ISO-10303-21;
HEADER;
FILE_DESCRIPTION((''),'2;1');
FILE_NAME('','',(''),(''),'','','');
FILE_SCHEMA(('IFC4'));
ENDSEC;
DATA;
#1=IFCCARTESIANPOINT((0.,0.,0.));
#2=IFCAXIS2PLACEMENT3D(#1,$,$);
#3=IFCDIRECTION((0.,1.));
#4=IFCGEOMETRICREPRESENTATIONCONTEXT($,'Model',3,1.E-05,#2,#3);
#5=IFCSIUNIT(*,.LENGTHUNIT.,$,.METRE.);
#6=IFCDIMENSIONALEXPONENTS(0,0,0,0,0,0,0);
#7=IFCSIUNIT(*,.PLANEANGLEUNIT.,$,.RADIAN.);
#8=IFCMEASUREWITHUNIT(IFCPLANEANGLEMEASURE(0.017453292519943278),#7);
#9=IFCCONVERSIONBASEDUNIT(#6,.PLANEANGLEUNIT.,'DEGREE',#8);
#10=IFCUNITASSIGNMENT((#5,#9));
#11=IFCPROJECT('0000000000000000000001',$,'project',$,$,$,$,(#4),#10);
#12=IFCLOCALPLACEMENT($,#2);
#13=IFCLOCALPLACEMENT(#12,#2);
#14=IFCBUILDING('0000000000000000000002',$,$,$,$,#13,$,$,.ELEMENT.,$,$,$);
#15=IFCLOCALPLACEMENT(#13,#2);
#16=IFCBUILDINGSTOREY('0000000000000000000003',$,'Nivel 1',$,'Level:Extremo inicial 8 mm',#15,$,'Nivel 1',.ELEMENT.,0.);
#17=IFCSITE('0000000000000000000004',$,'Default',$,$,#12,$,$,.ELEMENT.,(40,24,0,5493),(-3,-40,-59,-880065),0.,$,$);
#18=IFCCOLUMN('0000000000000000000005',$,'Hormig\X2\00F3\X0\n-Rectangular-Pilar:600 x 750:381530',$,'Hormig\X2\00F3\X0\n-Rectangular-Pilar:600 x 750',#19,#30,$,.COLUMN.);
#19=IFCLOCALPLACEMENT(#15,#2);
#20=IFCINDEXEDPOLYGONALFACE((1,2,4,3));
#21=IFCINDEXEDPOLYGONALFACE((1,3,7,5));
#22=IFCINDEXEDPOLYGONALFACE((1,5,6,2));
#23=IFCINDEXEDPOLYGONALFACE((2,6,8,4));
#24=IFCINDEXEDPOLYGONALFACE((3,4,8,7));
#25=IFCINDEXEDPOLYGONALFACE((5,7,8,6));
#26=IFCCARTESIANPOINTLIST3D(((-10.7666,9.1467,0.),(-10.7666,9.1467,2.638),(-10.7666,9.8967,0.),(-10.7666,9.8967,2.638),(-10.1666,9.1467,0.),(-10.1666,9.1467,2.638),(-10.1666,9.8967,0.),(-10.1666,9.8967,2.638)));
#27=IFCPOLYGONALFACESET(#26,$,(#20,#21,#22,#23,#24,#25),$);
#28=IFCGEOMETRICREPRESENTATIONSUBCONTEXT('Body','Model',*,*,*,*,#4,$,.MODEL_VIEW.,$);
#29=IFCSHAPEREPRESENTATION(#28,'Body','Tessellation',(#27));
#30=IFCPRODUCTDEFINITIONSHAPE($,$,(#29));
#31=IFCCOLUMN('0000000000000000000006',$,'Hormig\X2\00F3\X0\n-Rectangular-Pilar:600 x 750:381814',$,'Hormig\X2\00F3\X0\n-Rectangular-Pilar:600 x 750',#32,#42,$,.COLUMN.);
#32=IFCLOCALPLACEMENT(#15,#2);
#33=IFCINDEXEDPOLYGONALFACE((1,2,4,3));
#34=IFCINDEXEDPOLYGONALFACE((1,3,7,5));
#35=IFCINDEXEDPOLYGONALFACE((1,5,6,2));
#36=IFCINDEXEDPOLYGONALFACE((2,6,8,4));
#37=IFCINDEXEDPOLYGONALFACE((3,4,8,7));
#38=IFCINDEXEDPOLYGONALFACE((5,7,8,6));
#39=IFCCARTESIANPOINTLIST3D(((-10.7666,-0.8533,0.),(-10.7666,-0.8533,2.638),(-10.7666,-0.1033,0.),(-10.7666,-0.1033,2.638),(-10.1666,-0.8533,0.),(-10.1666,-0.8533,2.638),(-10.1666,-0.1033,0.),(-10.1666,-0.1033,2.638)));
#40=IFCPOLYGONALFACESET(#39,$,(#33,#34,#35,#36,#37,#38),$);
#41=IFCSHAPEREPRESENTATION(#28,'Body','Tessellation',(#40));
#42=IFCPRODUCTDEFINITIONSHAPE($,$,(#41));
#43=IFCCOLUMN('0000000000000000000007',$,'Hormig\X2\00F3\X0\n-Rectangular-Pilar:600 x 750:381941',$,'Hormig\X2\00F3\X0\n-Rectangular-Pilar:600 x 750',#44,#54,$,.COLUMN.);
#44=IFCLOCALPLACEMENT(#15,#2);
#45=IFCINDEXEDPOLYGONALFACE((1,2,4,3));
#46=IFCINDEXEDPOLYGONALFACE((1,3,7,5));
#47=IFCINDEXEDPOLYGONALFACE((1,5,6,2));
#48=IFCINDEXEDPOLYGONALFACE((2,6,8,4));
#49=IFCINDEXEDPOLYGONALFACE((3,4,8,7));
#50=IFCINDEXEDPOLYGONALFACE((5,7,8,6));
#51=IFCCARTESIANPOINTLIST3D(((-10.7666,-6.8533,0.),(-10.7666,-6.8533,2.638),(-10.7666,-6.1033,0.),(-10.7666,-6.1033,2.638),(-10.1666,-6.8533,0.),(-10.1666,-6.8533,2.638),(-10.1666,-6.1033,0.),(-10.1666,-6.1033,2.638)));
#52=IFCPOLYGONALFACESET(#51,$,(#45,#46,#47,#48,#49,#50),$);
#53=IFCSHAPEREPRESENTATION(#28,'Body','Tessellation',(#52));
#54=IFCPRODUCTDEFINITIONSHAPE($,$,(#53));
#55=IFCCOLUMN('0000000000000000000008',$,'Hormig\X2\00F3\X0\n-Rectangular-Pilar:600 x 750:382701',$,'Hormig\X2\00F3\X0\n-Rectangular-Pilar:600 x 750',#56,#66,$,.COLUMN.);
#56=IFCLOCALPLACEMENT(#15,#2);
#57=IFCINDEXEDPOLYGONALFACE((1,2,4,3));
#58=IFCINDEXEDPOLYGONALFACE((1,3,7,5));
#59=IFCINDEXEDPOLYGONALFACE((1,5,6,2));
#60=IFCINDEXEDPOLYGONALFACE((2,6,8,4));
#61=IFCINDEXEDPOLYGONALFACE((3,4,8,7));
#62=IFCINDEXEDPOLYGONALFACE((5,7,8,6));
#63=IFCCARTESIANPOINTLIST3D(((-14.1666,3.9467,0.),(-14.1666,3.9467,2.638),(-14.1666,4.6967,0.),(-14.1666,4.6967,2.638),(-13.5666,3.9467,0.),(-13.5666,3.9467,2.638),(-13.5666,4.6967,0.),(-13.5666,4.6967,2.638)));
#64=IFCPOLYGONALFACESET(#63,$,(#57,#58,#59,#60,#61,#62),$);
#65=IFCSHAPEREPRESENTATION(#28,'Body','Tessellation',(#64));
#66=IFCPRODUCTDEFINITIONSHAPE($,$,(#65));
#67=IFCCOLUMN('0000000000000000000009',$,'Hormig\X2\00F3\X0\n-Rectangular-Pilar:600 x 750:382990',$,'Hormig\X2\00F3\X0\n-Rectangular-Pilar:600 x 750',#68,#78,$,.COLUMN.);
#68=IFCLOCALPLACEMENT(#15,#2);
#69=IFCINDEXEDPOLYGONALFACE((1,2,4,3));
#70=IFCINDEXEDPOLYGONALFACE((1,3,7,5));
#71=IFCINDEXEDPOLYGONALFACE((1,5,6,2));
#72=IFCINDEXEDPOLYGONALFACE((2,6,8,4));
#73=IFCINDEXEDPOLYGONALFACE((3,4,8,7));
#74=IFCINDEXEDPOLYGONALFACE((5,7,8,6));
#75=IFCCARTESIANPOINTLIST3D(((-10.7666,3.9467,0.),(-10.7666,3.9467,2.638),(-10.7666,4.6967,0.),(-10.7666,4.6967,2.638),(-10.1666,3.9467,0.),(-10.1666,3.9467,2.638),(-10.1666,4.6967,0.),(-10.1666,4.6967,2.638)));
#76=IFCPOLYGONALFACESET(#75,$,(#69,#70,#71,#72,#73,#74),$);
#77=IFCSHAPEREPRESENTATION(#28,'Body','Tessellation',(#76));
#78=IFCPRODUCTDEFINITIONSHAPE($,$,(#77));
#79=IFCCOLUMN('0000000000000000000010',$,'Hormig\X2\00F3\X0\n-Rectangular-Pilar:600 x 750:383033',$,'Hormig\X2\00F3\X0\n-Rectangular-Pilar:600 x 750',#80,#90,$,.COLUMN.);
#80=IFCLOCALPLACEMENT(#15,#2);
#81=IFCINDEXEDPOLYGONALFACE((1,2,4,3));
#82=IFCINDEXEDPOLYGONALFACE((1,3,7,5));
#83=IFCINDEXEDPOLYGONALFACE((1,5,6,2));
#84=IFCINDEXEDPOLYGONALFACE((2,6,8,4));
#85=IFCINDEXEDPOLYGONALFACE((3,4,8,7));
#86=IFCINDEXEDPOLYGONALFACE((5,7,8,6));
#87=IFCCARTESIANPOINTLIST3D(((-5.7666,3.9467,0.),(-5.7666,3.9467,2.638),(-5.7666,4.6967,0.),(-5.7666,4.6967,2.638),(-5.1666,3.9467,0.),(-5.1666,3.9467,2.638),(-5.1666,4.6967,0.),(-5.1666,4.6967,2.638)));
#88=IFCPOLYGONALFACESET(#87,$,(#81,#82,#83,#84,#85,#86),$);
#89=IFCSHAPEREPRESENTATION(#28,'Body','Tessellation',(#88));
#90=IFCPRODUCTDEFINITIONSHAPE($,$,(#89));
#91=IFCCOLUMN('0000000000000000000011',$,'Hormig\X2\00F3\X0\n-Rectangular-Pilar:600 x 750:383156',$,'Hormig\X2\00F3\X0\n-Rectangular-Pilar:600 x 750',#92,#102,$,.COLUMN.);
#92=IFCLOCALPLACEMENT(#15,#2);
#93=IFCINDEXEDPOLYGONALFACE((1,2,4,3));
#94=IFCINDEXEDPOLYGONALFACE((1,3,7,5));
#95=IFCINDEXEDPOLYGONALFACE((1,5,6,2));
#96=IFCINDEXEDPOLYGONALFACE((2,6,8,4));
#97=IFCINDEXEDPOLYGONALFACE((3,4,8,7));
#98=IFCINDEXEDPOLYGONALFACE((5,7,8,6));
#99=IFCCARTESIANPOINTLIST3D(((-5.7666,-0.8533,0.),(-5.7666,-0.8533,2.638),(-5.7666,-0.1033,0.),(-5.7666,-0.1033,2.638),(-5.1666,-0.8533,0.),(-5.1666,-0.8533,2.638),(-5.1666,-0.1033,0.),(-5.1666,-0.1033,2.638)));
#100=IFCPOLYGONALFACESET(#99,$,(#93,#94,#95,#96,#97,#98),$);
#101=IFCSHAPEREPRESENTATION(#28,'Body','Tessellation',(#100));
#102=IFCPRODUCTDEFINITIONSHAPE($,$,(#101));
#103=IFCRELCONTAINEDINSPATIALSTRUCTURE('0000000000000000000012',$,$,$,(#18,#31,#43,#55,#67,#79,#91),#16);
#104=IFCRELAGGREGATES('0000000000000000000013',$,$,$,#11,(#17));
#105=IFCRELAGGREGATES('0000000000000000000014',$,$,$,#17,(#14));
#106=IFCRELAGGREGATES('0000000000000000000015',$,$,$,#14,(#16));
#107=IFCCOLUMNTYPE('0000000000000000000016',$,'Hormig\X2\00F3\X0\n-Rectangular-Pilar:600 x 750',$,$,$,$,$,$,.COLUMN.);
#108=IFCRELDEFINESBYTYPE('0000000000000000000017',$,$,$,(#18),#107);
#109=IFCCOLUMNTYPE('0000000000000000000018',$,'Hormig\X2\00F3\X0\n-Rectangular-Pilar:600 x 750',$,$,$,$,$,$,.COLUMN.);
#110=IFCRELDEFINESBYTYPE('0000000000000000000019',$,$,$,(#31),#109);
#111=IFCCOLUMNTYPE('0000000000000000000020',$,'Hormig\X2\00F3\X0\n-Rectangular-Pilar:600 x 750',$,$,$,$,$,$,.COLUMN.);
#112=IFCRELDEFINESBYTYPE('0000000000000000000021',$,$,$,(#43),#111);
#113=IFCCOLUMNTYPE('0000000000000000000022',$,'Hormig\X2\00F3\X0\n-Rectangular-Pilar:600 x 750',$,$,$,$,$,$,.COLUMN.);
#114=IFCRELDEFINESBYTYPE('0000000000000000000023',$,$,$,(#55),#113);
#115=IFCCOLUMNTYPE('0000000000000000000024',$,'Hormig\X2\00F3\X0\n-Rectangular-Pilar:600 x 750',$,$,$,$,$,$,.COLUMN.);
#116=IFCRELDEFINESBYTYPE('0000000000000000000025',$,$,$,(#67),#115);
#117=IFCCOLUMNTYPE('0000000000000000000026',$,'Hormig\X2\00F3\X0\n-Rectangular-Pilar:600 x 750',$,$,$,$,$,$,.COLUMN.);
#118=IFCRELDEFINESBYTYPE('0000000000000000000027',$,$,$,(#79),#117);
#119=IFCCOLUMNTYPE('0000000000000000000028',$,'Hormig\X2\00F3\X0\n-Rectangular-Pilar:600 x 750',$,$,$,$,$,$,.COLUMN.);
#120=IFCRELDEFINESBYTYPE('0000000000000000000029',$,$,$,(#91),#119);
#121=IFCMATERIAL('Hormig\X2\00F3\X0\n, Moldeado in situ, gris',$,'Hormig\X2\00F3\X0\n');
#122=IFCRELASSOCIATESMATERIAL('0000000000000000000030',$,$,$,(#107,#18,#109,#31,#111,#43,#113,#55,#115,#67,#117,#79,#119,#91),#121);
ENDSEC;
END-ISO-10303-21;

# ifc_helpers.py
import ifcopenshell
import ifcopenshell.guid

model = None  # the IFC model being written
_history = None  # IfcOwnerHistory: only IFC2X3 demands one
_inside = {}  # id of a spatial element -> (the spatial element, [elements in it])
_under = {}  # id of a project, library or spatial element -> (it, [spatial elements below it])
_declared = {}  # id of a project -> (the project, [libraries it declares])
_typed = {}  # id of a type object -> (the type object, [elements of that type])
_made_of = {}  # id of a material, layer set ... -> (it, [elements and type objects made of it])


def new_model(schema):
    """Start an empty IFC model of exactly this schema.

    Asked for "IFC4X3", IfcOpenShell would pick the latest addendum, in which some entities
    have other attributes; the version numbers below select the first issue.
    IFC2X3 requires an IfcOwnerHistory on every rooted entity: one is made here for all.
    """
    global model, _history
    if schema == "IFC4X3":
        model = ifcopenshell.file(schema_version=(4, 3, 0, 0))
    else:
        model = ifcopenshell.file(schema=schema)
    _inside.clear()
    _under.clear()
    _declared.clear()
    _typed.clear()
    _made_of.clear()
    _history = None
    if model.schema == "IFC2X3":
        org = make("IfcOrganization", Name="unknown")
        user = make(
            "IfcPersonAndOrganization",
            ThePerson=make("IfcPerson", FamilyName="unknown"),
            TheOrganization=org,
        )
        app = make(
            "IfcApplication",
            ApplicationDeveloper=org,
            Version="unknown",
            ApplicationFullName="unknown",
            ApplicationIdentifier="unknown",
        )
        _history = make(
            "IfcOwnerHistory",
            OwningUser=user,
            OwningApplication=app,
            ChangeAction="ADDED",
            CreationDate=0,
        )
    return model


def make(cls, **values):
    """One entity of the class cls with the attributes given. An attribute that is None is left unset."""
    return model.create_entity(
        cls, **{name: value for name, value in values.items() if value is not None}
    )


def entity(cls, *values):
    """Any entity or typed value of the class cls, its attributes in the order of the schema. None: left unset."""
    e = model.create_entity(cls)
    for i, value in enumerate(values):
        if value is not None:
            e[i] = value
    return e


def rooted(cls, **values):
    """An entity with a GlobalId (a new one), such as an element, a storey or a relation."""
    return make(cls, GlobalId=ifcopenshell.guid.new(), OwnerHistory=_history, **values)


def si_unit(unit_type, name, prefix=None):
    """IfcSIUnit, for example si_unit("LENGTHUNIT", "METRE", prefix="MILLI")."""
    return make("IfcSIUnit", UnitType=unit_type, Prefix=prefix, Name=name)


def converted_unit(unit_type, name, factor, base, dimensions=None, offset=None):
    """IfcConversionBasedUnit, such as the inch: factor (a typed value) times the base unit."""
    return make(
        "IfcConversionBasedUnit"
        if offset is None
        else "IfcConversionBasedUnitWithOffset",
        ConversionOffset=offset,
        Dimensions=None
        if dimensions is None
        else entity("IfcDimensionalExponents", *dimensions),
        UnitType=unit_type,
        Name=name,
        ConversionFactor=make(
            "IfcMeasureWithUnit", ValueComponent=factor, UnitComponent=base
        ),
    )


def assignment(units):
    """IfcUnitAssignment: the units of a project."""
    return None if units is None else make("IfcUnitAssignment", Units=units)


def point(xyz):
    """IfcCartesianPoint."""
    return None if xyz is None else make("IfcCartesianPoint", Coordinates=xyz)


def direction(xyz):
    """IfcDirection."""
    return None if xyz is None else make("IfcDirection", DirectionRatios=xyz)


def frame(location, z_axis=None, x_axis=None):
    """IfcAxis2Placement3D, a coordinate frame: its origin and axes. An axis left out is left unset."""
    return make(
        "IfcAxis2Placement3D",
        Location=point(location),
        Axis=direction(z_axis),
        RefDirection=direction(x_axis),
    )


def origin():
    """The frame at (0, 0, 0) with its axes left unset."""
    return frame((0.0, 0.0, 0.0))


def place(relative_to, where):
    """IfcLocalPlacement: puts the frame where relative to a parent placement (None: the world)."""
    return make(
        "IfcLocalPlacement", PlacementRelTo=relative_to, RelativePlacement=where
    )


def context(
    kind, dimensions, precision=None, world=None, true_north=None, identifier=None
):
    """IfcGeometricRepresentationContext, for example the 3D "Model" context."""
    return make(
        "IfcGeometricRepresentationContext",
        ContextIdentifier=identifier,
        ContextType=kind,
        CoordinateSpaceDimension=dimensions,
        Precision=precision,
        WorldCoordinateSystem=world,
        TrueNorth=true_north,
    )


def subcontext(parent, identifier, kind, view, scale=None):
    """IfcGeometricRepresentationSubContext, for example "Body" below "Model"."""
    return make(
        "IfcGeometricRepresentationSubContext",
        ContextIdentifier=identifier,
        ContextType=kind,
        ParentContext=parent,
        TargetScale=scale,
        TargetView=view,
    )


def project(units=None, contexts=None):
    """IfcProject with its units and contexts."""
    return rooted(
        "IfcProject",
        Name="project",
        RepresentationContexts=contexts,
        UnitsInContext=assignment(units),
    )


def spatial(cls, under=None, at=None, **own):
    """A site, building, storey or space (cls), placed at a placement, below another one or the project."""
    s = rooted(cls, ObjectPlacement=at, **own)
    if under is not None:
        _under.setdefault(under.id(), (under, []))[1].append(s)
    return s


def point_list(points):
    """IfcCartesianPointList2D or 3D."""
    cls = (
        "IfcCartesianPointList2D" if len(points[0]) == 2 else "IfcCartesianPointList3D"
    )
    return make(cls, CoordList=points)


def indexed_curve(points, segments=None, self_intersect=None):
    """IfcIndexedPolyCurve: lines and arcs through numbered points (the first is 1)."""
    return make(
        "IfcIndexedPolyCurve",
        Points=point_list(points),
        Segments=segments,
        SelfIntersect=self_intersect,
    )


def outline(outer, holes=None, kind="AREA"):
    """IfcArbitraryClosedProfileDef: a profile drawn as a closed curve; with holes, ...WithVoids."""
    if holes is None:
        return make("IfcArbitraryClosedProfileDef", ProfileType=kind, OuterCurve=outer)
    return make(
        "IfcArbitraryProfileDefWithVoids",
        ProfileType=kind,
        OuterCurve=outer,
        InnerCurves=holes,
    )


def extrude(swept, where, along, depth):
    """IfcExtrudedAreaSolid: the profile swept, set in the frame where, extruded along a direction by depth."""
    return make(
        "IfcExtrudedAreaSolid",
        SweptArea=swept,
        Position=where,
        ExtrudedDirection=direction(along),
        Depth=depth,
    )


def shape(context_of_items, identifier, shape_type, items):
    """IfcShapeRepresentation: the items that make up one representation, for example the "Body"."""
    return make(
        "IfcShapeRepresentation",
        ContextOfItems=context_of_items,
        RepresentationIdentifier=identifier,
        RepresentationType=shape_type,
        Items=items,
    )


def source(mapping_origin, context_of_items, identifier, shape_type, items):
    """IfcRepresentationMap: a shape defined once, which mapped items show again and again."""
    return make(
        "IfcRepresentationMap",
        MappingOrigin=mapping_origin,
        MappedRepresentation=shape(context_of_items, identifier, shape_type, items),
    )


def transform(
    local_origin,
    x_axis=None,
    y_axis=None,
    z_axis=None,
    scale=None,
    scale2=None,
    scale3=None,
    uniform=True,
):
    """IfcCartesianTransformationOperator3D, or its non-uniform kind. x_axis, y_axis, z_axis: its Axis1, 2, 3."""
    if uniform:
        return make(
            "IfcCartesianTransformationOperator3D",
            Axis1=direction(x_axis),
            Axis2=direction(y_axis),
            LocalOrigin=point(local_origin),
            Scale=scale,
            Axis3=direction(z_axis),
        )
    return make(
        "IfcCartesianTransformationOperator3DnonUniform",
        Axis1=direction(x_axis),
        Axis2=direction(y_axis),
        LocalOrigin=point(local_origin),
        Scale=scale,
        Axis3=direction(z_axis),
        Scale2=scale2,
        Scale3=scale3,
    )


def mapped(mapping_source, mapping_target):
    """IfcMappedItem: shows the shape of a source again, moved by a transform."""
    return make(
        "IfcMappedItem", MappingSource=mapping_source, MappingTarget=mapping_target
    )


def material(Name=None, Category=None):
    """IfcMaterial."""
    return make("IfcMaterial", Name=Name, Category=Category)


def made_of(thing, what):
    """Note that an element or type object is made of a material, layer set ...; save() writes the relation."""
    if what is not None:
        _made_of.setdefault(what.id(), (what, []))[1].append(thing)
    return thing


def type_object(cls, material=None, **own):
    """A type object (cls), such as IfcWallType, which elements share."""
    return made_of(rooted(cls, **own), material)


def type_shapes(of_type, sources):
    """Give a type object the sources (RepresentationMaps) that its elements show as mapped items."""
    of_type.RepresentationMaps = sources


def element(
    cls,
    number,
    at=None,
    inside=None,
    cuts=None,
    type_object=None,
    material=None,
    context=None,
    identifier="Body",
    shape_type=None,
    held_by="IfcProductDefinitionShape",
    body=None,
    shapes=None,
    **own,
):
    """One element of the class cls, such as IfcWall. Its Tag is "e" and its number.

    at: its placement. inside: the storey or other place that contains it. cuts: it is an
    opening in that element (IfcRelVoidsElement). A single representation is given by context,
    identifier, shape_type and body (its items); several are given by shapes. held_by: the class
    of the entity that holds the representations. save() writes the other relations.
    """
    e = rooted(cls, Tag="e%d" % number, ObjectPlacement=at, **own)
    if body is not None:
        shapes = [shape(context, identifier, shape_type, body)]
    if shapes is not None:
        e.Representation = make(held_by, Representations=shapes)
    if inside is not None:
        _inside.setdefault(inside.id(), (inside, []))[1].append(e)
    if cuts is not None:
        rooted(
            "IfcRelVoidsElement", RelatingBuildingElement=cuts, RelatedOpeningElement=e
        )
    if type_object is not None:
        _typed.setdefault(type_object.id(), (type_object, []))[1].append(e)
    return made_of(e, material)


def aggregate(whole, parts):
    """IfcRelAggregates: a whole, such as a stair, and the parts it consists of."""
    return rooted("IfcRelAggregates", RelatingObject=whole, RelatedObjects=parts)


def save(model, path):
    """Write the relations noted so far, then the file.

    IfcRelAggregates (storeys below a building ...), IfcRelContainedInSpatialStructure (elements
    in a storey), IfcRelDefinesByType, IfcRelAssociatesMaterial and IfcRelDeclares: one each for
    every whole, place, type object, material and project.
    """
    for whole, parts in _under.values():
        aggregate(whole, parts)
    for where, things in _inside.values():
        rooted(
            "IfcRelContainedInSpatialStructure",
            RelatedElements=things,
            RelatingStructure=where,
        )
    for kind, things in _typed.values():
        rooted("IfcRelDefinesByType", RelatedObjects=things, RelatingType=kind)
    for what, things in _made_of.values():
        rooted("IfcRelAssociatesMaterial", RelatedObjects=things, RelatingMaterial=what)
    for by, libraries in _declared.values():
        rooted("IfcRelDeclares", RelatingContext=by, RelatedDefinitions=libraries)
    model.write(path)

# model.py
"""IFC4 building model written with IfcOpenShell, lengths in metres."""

from ifc_helpers import new_model, entity, si_unit, converted_unit, direction, frame, origin, place, context, subcontext, project, spatial, indexed_curve, outline, extrude, source, transform, mapped, material, type_object, type_shapes, element, save


model = new_model("IFC4")

# Units and contexts
model_context = context("Model", 3, precision=1e-05, world=origin(), true_north=direction((0.0, 1.0)))
body_context = subcontext(model_context, "Body", "Model", "MODEL_VIEW")
ifc_project = project(units=[si_unit("LENGTHUNIT", "METRE"), converted_unit("PLANEANGLEUNIT", "DEGREE", entity("IfcPlaneAngleMeasure", 0.017453292519943278), si_unit("PLANEANGLEUNIT", "RADIAN"), dimensions=[0, 0, 0, 0, 0, 0, 0])], contexts=[model_context])

# Site, building, storey
site_placement = place(None, origin())
site = spatial("IfcSite", under=ifc_project, at=site_placement, Name="Default", CompositionType="ELEMENT", RefLatitude=(40, 24, 0, 5493), RefLongitude=(-3, -40, -59, -880065), RefElevation=0.0)
building_placement = place(site_placement, origin())
building = spatial("IfcBuilding", under=site, at=building_placement, CompositionType="ELEMENT")
storey_placement = place(building_placement, origin())
storey = spatial("IfcBuildingStorey", under=building, at=storey_placement, Name="Nivel 1", ObjectType="Level:Extremo inicial 8 mm", LongName="Nivel 1", CompositionType="ELEMENT", Elevation=0.0)

# Columns
ifc_material = material(Name="Hormigón, Moldeado in situ, gris", Category="Hormigón")
column_type_1 = type_object("IfcColumnType", Name="Hormigón-Rectangular-Pilar:600 x 750", PredefinedType="COLUMN", material=ifc_material)
shared_shape_1 = source(origin(), body_context, "Body", "SweptSolid", [
    extrude(outline(indexed_curve([(-1.319, -0.375), (1.319, -0.375), (1.319, 0.375), (-1.319, 0.375), (-1.319, -0.375)], self_intersect=False)), frame((-10.7666, 9.5217, 1.319), z_axis=(1.0, 0.0, 0.0), x_axis=(0.0, 0.0, 1.0)), (0.0, 0.0, 1.0), 0.6),
])
type_shapes(column_type_1, [shared_shape_1])
column_1_placement = place(storey_placement, origin())
element("IfcColumn", 1, at=column_1_placement, inside=storey, type_object=column_type_1, material=ifc_material, Name="Hormigón-Rectangular-Pilar:600 x 750:381530", ObjectType="Hormigón-Rectangular-Pilar:600 x 750", PredefinedType="COLUMN", context=body_context, shape_type="MappedRepresentation", body=[
    mapped(shared_shape_1, transform((0.0, 0.0, 0.0), scale=1.0)),
])
column_type_2 = type_object("IfcColumnType", Name="Hormigón-Rectangular-Pilar:600 x 750", PredefinedType="COLUMN", material=ifc_material)
shared_shape_2 = source(origin(), body_context, "Body", "SweptSolid", [
    extrude(outline(indexed_curve([(-1.319, -0.375), (1.319, -0.375), (1.319, 0.375), (-1.319, 0.375), (-1.319, -0.375)], self_intersect=False)), frame((-10.7666, -0.4783, 1.319), z_axis=(1.0, 0.0, 0.0), x_axis=(0.0, 0.0, 1.0)), (0.0, 0.0, 1.0), 0.6),
])
type_shapes(column_type_2, [shared_shape_2])
column_2_placement = place(storey_placement, origin())
element("IfcColumn", 2, at=column_2_placement, inside=storey, type_object=column_type_2, material=ifc_material, Name="Hormigón-Rectangular-Pilar:600 x 750:381814", ObjectType="Hormigón-Rectangular-Pilar:600 x 750", PredefinedType="COLUMN", context=body_context, shape_type="MappedRepresentation", body=[
    mapped(shared_shape_2, transform((0.0, 0.0, 0.0), scale=1.0)),
])
column_type_3 = type_object("IfcColumnType", Name="Hormigón-Rectangular-Pilar:600 x 750", PredefinedType="COLUMN", material=ifc_material)
shared_shape_3 = source(origin(), body_context, "Body", "SweptSolid", [
    extrude(outline(indexed_curve([(-1.319, -0.375), (1.319, -0.375), (1.319, 0.375), (-1.319, 0.375), (-1.319, -0.375)], self_intersect=False)), frame((-10.7666, -6.4783, 1.319), z_axis=(1.0, 0.0, 0.0), x_axis=(0.0, 0.0, 1.0)), (0.0, 0.0, 1.0), 0.6),
])
type_shapes(column_type_3, [shared_shape_3])
column_3_placement = place(storey_placement, origin())
element("IfcColumn", 3, at=column_3_placement, inside=storey, type_object=column_type_3, material=ifc_material, Name="Hormigón-Rectangular-Pilar:600 x 750:381941", ObjectType="Hormigón-Rectangular-Pilar:600 x 750", PredefinedType="COLUMN", context=body_context, shape_type="MappedRepresentation", body=[
    mapped(shared_shape_3, transform((0.0, 0.0, 0.0), scale=1.0)),
])
column_type_4 = type_object("IfcColumnType", Name="Hormigón-Rectangular-Pilar:600 x 750", PredefinedType="COLUMN", material=ifc_material)
shared_shape_4 = source(origin(), body_context, "Body", "SweptSolid", [
    extrude(outline(indexed_curve([(-1.319, -0.375), (1.319, -0.375), (1.319, 0.375), (-1.319, 0.375), (-1.319, -0.375)], self_intersect=False)), frame((-14.1666, 4.3217, 1.319), z_axis=(1.0, 0.0, 0.0), x_axis=(0.0, 0.0, 1.0)), (0.0, 0.0, 1.0), 0.6),
])
type_shapes(column_type_4, [shared_shape_4])
column_4_placement = place(storey_placement, origin())
element("IfcColumn", 4, at=column_4_placement, inside=storey, type_object=column_type_4, material=ifc_material, Name="Hormigón-Rectangular-Pilar:600 x 750:382701", ObjectType="Hormigón-Rectangular-Pilar:600 x 750", PredefinedType="COLUMN", context=body_context, shape_type="MappedRepresentation", body=[
    mapped(shared_shape_4, transform((0.0, 0.0, 0.0), scale=1.0)),
])
column_type_5 = type_object("IfcColumnType", Name="Hormigón-Rectangular-Pilar:600 x 750", PredefinedType="COLUMN", material=ifc_material)
shared_shape_5 = source(origin(), body_context, "Body", "SweptSolid", [
    extrude(outline(indexed_curve([(-1.319, -0.375), (1.319, -0.375), (1.319, 0.375), (-1.319, 0.375), (-1.319, -0.375)], self_intersect=False)), frame((-10.7666, 4.3217, 1.319), z_axis=(1.0, 0.0, 0.0), x_axis=(0.0, 0.0, 1.0)), (0.0, 0.0, 1.0), 0.6),
])
type_shapes(column_type_5, [shared_shape_5])
column_5_placement = place(storey_placement, origin())
element("IfcColumn", 5, at=column_5_placement, inside=storey, type_object=column_type_5, material=ifc_material, Name="Hormigón-Rectangular-Pilar:600 x 750:382990", ObjectType="Hormigón-Rectangular-Pilar:600 x 750", PredefinedType="COLUMN", context=body_context, shape_type="MappedRepresentation", body=[
    mapped(shared_shape_5, transform((0.0, 0.0, 0.0), scale=1.0)),
])
column_type_6 = type_object("IfcColumnType", Name="Hormigón-Rectangular-Pilar:600 x 750", PredefinedType="COLUMN", material=ifc_material)
shared_shape_6 = source(origin(), body_context, "Body", "SweptSolid", [
    extrude(outline(indexed_curve([(-1.319, -0.375), (1.319, -0.375), (1.319, 0.375), (-1.319, 0.375), (-1.319, -0.375)], self_intersect=False)), frame((-5.7666, 4.3217, 1.319), z_axis=(1.0, 0.0, 0.0), x_axis=(0.0, 0.0, 1.0)), (0.0, 0.0, 1.0), 0.6),
])
type_shapes(column_type_6, [shared_shape_6])
column_6_placement = place(storey_placement, origin())
element("IfcColumn", 6, at=column_6_placement, inside=storey, type_object=column_type_6, material=ifc_material, Name="Hormigón-Rectangular-Pilar:600 x 750:383033", ObjectType="Hormigón-Rectangular-Pilar:600 x 750", PredefinedType="COLUMN", context=body_context, shape_type="MappedRepresentation", body=[
    mapped(shared_shape_6, transform((0.0, 0.0, 0.0), scale=1.0)),
])
column_type_7 = type_object("IfcColumnType", Name="Hormigón-Rectangular-Pilar:600 x 750", PredefinedType="COLUMN", material=ifc_material)
shared_shape_7 = source(origin(), body_context, "Body", "SweptSolid", [
    extrude(outline(indexed_curve([(-1.319, -0.375), (1.319, -0.375), (1.319, 0.375), (-1.319, 0.375), (-1.319, -0.375)], self_intersect=False)), frame((-5.7666, -0.4783, 1.319), z_axis=(1.0, 0.0, 0.0), x_axis=(0.0, 0.0, 1.0)), (0.0, 0.0, 1.0), 0.6),
])
type_shapes(column_type_7, [shared_shape_7])
column_7_placement = place(storey_placement, origin())
element("IfcColumn", 7, at=column_7_placement, inside=storey, type_object=column_type_7, material=ifc_material, Name="Hormigón-Rectangular-Pilar:600 x 750:383156", ObjectType="Hormigón-Rectangular-Pilar:600 x 750", PredefinedType="COLUMN", context=body_context, shape_type="MappedRepresentation", body=[
    mapped(shared_shape_7, transform((0.0, 0.0, 0.0), scale=1.0)),
])

save(model, "model.ifc")
